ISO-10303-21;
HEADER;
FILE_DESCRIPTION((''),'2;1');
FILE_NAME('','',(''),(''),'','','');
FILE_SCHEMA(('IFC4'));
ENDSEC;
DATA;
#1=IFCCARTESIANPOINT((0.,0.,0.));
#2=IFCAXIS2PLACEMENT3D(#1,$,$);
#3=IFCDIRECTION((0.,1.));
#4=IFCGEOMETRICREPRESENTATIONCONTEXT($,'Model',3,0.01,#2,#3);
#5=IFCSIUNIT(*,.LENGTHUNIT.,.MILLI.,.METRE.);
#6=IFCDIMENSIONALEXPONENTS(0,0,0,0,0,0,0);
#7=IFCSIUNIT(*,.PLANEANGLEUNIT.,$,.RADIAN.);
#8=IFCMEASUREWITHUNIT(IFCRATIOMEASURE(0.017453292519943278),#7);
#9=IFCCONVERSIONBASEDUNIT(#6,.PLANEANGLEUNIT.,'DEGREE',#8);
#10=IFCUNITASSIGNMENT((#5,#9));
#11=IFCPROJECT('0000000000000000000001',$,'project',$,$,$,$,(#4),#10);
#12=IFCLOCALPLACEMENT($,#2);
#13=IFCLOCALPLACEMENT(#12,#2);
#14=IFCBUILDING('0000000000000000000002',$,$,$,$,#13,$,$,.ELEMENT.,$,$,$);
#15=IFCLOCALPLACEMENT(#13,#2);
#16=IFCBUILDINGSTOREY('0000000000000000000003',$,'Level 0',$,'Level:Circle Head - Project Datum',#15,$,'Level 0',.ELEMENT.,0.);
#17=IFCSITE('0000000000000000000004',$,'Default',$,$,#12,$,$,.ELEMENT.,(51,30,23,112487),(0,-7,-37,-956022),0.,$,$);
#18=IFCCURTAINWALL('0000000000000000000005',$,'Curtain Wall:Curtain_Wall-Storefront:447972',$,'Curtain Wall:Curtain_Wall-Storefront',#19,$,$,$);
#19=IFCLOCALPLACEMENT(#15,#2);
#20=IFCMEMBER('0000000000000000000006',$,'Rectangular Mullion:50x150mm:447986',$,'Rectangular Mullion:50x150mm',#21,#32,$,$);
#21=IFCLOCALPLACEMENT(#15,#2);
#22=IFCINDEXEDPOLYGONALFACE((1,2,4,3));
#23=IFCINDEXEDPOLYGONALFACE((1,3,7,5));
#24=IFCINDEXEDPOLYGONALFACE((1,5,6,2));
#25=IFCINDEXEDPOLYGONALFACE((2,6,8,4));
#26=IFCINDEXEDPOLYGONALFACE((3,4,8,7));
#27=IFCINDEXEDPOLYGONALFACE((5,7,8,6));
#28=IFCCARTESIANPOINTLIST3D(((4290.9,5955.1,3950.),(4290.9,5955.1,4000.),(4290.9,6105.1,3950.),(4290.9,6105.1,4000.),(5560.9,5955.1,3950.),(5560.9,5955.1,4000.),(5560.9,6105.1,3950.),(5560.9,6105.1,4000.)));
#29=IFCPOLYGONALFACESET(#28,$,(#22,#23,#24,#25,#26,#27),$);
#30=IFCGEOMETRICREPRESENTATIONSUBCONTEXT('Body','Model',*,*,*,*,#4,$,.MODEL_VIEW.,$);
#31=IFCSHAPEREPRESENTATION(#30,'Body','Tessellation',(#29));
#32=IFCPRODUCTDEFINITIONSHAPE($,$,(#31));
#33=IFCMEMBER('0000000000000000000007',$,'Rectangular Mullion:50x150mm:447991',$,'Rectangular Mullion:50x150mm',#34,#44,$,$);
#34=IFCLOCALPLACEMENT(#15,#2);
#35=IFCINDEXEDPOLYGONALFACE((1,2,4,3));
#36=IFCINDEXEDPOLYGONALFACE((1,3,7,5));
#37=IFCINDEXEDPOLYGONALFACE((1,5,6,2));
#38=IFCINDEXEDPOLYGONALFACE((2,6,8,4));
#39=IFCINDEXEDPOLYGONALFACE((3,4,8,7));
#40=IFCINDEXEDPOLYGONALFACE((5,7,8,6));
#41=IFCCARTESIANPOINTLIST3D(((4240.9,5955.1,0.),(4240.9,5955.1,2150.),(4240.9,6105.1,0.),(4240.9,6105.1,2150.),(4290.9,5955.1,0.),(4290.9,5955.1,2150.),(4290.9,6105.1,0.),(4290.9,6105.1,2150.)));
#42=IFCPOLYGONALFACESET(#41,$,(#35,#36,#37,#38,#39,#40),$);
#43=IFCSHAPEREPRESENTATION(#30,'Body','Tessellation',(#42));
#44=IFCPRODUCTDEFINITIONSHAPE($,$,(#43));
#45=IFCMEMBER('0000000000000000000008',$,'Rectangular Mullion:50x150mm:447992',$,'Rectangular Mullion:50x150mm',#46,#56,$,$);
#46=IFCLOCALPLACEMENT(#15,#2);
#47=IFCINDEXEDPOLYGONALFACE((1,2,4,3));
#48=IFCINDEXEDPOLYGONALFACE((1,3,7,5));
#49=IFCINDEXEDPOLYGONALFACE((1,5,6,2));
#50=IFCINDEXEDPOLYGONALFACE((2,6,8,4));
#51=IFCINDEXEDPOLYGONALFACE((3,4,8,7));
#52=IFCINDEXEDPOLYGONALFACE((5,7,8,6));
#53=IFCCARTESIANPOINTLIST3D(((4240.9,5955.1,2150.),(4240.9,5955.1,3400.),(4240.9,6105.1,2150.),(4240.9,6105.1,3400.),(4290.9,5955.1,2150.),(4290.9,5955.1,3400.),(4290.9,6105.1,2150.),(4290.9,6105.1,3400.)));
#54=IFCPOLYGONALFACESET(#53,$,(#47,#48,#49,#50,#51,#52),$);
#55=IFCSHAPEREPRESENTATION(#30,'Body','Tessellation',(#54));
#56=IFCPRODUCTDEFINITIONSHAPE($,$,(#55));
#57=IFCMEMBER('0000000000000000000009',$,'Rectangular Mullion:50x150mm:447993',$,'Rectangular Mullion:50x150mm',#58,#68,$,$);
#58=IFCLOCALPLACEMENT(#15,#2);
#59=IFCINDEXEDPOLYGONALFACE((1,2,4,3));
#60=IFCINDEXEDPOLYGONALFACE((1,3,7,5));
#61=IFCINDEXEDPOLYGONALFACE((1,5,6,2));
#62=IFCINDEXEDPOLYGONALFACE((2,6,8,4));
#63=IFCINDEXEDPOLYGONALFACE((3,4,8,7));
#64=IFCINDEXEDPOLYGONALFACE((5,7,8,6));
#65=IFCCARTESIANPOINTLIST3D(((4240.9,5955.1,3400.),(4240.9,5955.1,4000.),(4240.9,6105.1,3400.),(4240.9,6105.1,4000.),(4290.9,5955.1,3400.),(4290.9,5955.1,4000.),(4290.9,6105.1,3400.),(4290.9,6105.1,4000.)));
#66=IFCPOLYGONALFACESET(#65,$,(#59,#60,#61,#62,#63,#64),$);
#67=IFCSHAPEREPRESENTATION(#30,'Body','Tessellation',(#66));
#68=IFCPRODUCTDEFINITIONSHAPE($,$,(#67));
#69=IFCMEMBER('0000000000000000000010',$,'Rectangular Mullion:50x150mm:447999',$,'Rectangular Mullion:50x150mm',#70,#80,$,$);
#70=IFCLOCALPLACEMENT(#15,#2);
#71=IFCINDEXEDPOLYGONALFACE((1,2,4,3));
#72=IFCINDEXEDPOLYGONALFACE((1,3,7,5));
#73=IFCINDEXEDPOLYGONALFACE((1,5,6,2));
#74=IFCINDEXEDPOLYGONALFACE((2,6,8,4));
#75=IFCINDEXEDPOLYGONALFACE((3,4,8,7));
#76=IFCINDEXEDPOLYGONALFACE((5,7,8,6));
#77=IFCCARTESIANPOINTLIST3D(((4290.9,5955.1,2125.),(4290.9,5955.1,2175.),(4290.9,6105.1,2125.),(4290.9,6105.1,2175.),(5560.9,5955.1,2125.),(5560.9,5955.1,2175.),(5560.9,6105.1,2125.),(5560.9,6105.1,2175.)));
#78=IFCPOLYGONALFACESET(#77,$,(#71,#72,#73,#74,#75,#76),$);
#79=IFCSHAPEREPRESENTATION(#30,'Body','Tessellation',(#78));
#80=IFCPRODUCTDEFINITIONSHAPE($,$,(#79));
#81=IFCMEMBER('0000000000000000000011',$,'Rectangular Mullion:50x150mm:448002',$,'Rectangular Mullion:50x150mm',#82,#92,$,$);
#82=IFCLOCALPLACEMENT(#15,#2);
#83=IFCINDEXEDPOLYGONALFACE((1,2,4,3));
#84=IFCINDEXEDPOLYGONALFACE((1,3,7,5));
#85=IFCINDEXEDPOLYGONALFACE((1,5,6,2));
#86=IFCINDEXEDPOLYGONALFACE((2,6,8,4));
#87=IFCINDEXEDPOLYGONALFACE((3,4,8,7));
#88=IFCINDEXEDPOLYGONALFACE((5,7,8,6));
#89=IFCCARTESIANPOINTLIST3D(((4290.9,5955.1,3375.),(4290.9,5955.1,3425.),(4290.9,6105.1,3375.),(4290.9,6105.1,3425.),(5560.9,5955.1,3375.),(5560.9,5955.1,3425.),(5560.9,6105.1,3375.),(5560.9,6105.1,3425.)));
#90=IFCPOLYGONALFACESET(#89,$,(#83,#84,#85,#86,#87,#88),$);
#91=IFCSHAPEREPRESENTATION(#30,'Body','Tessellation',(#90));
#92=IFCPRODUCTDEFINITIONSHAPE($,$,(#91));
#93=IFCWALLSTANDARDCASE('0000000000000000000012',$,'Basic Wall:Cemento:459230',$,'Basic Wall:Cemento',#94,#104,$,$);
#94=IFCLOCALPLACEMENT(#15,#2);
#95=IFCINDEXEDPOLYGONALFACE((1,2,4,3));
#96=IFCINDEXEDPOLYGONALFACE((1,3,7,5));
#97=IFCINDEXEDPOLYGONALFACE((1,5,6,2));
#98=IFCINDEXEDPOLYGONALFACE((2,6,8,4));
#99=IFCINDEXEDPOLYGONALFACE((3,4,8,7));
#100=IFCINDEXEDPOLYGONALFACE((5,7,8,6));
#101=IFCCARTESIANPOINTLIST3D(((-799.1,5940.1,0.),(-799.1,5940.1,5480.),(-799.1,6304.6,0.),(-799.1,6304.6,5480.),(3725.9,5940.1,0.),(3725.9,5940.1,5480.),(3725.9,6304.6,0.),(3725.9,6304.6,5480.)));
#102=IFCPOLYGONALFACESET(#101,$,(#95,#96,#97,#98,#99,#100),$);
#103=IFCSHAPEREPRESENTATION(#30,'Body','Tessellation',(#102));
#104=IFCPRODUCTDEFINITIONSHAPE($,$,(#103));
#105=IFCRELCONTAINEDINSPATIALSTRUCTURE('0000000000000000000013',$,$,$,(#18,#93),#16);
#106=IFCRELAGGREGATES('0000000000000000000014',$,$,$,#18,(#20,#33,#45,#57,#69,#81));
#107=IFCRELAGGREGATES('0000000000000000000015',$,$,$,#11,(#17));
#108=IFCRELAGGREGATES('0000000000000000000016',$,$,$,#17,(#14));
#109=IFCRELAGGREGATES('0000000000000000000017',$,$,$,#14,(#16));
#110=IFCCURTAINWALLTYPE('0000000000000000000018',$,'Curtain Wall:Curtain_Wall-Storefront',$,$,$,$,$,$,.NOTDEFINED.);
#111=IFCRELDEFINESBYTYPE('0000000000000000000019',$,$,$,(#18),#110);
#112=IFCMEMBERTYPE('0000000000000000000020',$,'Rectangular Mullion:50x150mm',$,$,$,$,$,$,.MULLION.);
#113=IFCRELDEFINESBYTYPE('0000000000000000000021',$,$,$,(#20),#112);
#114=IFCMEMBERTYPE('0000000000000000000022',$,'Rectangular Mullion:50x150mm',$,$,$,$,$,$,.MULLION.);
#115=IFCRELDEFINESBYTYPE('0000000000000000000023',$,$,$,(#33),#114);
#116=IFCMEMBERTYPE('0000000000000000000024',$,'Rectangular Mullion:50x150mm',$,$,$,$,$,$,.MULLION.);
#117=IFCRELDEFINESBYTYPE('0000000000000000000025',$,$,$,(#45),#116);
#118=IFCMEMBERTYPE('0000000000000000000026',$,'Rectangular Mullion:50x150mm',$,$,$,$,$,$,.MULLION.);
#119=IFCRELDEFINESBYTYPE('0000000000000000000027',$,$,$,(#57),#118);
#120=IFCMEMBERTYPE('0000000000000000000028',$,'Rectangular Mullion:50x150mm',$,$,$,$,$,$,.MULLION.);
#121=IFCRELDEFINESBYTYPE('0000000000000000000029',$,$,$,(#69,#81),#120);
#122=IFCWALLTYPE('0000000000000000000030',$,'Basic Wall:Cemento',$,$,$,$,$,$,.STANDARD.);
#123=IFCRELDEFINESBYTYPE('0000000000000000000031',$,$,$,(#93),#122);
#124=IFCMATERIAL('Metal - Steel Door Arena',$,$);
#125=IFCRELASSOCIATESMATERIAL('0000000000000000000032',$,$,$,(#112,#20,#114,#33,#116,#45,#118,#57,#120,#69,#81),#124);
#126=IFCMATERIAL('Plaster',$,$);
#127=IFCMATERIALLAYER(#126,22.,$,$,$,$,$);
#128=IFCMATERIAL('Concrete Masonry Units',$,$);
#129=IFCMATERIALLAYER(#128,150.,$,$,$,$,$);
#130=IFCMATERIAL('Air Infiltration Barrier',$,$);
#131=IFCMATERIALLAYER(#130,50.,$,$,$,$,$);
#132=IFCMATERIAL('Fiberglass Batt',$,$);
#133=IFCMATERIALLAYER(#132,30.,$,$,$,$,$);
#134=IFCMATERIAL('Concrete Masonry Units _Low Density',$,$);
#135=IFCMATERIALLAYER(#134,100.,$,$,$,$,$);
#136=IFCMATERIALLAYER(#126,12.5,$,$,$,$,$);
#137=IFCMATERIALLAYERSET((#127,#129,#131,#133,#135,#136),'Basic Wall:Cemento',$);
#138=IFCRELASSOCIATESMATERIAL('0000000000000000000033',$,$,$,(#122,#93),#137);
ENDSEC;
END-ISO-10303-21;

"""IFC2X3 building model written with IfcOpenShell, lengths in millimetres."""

from ifc_helpers import new_model, entity, si_unit, converted_unit, direction, frame, frame_2d, origin, origin_2d_with_axis, place, context, subcontext, project, spatial, rectangle, extrude, source, transform, mapped, material, layer, layer_set, layer_usage, type_object, type_shapes, element, aggregate, save


model = new_model("IFC2X3")

# Units and contexts
model_context = context("Model", 3, precision=0.01, world=origin(), true_north=direction((0.0, 1.0)))
body_context = subcontext(model_context, "Body", "Model", "MODEL_VIEW")
ifc_project = project(units=[si_unit("LENGTHUNIT", "METRE", prefix="MILLI"), converted_unit("PLANEANGLEUNIT", "DEGREE", entity("IfcRatioMeasure", 0.017453292519943278), si_unit("PLANEANGLEUNIT", "RADIAN"), dimensions=[0, 0, 0, 0, 0, 0, 0])], contexts=[model_context])

# Site, building, storey
site_placement = place(None, origin())
site = spatial("IfcSite", under=ifc_project, at=site_placement, Name="Default", CompositionType="ELEMENT", RefLatitude=(51, 30, 23, 112487), RefLongitude=(0, -7, -37, -956022), RefElevation=0.0)
building_placement = place(site_placement, origin())
building = spatial("IfcBuilding", under=site, at=building_placement, CompositionType="ELEMENT")
storey_placement = place(building_placement, origin())
storey = spatial("IfcBuildingStorey", under=building, at=storey_placement, Name="Level 0", ObjectType="Level:Circle Head - Project Datum", LongName="Level 0", CompositionType="ELEMENT", Elevation=0.0)

# Shared definitions
ifc_material_1 = material(Name="Plaster")

# Curtain wall, members
curtain_wall_type = type_object("IfcCurtainWallType", Name="Curtain Wall:Curtain_Wall-Storefront", PredefinedType="NOTDEFINED")
curtain_wall_placement = place(storey_placement, origin())
curtain_wall = element("IfcCurtainWall", 1, at=curtain_wall_placement, inside=storey, type_object=curtain_wall_type, Name="Curtain Wall:Curtain_Wall-Storefront:447972", ObjectType="Curtain Wall:Curtain_Wall-Storefront")
ifc_material_2 = material(Name="Metal - Steel Door Arena")
member_type_1 = type_object("IfcMemberType", Name="Rectangular Mullion:50x150mm", PredefinedType="MULLION", material=ifc_material_2)
shared_shape_1 = source(origin(), body_context, "Body", "SweptSolid", [
    extrude(rectangle(XDim=150.0, YDim=50.0, at=origin_2d_with_axis()), frame((-25.0, 0.0, -1270.0), z_axis=(0.0, 0.0, 1.0), x_axis=(0.0, -1.0, 0.0)), (0.0, 0.0, 1.0), 1270.0),
])
type_shapes(member_type_1, [shared_shape_1])
member_1_placement = place(curtain_wall_placement, frame((4290.9, 6030.1, 4000.0), z_axis=(-1.0, 0.0, 0.0), x_axis=(0.0, 0.0, 1.0)))
member_1 = element("IfcMember", 2, at=member_1_placement, type_object=member_type_1, material=ifc_material_2, Name="Rectangular Mullion:50x150mm:447986", ObjectType="Rectangular Mullion:50x150mm", context=body_context, shape_type="MappedRepresentation", body=[
    mapped(shared_shape_1, transform((0.0, 0.0, 0.0), scale=1.0)),
])
member_type_2 = type_object("IfcMemberType", Name="Rectangular Mullion:50x150mm", PredefinedType="MULLION", material=ifc_material_2)
shared_shape_2 = source(origin(), body_context, "Body", "SweptSolid", [
    extrude(rectangle(XDim=150.0, YDim=50.0, at=origin_2d_with_axis()), frame((-25.0, 0.0, -2150.0), z_axis=(0.0, 0.0, 1.0), x_axis=(0.0, -1.0, 0.0)), (0.0, 0.0, 1.0), 2150.0),
])
type_shapes(member_type_2, [shared_shape_2])
member_2_placement = place(curtain_wall_placement, frame((4240.9, 6030.1, 0.0), z_axis=(0.0, 0.0, -1.0), x_axis=(-1.0, 0.0, 0.0)))
member_2 = element("IfcMember", 3, at=member_2_placement, type_object=member_type_2, material=ifc_material_2, Name="Rectangular Mullion:50x150mm:447991", ObjectType="Rectangular Mullion:50x150mm", context=body_context, shape_type="MappedRepresentation", body=[
    mapped(shared_shape_2, transform((0.0, 0.0, 0.0), scale=1.0)),
])
member_type_3 = type_object("IfcMemberType", Name="Rectangular Mullion:50x150mm", PredefinedType="MULLION", material=ifc_material_2)
shared_shape_3 = source(origin(), body_context, "Body", "SweptSolid", [
    extrude(rectangle(XDim=150.0, YDim=50.0, at=origin_2d_with_axis()), frame((-25.0, 0.0, -1250.0), z_axis=(0.0, 0.0, 1.0), x_axis=(0.0, -1.0, 0.0)), (0.0, 0.0, 1.0), 1250.0),
])
type_shapes(member_type_3, [shared_shape_3])
member_3_placement = place(curtain_wall_placement, frame((4240.9, 6030.1, 2150.0), z_axis=(0.0, 0.0, -1.0), x_axis=(-1.0, 0.0, 0.0)))
member_3 = element("IfcMember", 4, at=member_3_placement, type_object=member_type_3, material=ifc_material_2, Name="Rectangular Mullion:50x150mm:447992", ObjectType="Rectangular Mullion:50x150mm", context=body_context, shape_type="MappedRepresentation", body=[
    mapped(shared_shape_3, transform((0.0, 0.0, 0.0), scale=1.0)),
])
member_type_4 = type_object("IfcMemberType", Name="Rectangular Mullion:50x150mm", PredefinedType="MULLION", material=ifc_material_2)
shared_shape_4 = source(origin(), body_context, "Body", "SweptSolid", [
    extrude(rectangle(XDim=150.0, YDim=50.0, at=origin_2d_with_axis()), frame((-25.0, 0.0, -600.0), z_axis=(0.0, 0.0, 1.0), x_axis=(0.0, -1.0, 0.0)), (0.0, 0.0, 1.0), 600.0),
])
type_shapes(member_type_4, [shared_shape_4])
member_4_placement = place(curtain_wall_placement, frame((4240.9, 6030.1, 3400.0), z_axis=(0.0, 0.0, -1.0), x_axis=(-1.0, 0.0, 0.0)))
member_4 = element("IfcMember", 5, at=member_4_placement, type_object=member_type_4, material=ifc_material_2, Name="Rectangular Mullion:50x150mm:447993", ObjectType="Rectangular Mullion:50x150mm", context=body_context, shape_type="MappedRepresentation", body=[
    mapped(shared_shape_4, transform((0.0, 0.0, 0.0), scale=1.0)),
])
member_type_5 = type_object("IfcMemberType", Name="Rectangular Mullion:50x150mm", PredefinedType="MULLION", material=ifc_material_2)
shared_shape_5 = source(origin(), body_context, "Body", "SweptSolid", [
    extrude(rectangle(XDim=150.0, YDim=50.0, at=origin_2d_with_axis()), frame((0.0, 0.0, -1270.0), z_axis=(0.0, 0.0, 1.0), x_axis=(0.0, -1.0, 0.0)), (0.0, 0.0, 1.0), 1270.0),
])
type_shapes(member_type_5, [shared_shape_5])
member_5_placement = place(curtain_wall_placement, frame((4290.9, 6030.1, 2150.0), z_axis=(-1.0, 0.0, 0.0), x_axis=(0.0, 0.0, 1.0)))
member_5 = element("IfcMember", 6, at=member_5_placement, type_object=member_type_5, material=ifc_material_2, Name="Rectangular Mullion:50x150mm:447999", ObjectType="Rectangular Mullion:50x150mm", context=body_context, shape_type="MappedRepresentation", body=[
    mapped(shared_shape_5, transform((0.0, 0.0, 0.0), scale=1.0)),
])
member_6_placement = place(curtain_wall_placement, frame((4290.9, 6030.1, 3400.0), z_axis=(-1.0, 0.0, 0.0), x_axis=(0.0, 0.0, 1.0)))
member_6 = element("IfcMember", 7, at=member_6_placement, type_object=member_type_5, material=ifc_material_2, Name="Rectangular Mullion:50x150mm:448002", ObjectType="Rectangular Mullion:50x150mm", context=body_context, shape_type="MappedRepresentation", body=[
    mapped(shared_shape_5, transform((0.0, 0.0, 0.0), scale=1.0)),
])
aggregate(curtain_wall, [member_1, member_2, member_3, member_4, member_5, member_6])

# Wall
ifc_layer_1 = layer(ifc_material_1, 22.0)
ifc_material_3 = material(Name="Concrete Masonry Units")
ifc_layer_2 = layer(ifc_material_3, 150.0)
ifc_material_4 = material(Name="Air Infiltration Barrier")
ifc_layer_3 = layer(ifc_material_4, 50.0)
ifc_material_5 = material(Name="Fiberglass Batt")
ifc_layer_4 = layer(ifc_material_5, 30.0)
ifc_material_6 = material(Name="Concrete Masonry Units _Low Density")
ifc_layer_5 = layer(ifc_material_6, 100.0)
ifc_layer_6 = layer(ifc_material_1, 12.5)
ifc_layer_set = layer_set([ifc_layer_1, ifc_layer_2, ifc_layer_3, ifc_layer_4, ifc_layer_5, ifc_layer_6], Name="Basic Wall:Cemento")
ifc_layer_usage = layer_usage(ifc_layer_set, "AXIS2", "NEGATIVE", 182.3)
wall_type = type_object("IfcWallType", Name="Basic Wall:Cemento", PredefinedType="STANDARD", material=ifc_layer_set)
wall_placement = place(storey_placement, frame((3725.9, 6122.4, 0.0), z_axis=(0.0, 0.0, 1.0), x_axis=(-1.0, 0.0, 0.0)))
element("IfcWallStandardCase", 8, at=wall_placement, inside=storey, type_object=wall_type, material=ifc_layer_usage, Name="Basic Wall:Cemento:459230", ObjectType="Basic Wall:Cemento", context=body_context, shape_type="SweptSolid", body=[
    extrude(rectangle(XDim=4525.0, YDim=364.5, at=frame_2d((2262.5, 0.0), x_axis=(-1.0, 0.0))), origin(), (0.0, 0.0, 1.0), 5480.0),
])

save(model, "model.ifc")
